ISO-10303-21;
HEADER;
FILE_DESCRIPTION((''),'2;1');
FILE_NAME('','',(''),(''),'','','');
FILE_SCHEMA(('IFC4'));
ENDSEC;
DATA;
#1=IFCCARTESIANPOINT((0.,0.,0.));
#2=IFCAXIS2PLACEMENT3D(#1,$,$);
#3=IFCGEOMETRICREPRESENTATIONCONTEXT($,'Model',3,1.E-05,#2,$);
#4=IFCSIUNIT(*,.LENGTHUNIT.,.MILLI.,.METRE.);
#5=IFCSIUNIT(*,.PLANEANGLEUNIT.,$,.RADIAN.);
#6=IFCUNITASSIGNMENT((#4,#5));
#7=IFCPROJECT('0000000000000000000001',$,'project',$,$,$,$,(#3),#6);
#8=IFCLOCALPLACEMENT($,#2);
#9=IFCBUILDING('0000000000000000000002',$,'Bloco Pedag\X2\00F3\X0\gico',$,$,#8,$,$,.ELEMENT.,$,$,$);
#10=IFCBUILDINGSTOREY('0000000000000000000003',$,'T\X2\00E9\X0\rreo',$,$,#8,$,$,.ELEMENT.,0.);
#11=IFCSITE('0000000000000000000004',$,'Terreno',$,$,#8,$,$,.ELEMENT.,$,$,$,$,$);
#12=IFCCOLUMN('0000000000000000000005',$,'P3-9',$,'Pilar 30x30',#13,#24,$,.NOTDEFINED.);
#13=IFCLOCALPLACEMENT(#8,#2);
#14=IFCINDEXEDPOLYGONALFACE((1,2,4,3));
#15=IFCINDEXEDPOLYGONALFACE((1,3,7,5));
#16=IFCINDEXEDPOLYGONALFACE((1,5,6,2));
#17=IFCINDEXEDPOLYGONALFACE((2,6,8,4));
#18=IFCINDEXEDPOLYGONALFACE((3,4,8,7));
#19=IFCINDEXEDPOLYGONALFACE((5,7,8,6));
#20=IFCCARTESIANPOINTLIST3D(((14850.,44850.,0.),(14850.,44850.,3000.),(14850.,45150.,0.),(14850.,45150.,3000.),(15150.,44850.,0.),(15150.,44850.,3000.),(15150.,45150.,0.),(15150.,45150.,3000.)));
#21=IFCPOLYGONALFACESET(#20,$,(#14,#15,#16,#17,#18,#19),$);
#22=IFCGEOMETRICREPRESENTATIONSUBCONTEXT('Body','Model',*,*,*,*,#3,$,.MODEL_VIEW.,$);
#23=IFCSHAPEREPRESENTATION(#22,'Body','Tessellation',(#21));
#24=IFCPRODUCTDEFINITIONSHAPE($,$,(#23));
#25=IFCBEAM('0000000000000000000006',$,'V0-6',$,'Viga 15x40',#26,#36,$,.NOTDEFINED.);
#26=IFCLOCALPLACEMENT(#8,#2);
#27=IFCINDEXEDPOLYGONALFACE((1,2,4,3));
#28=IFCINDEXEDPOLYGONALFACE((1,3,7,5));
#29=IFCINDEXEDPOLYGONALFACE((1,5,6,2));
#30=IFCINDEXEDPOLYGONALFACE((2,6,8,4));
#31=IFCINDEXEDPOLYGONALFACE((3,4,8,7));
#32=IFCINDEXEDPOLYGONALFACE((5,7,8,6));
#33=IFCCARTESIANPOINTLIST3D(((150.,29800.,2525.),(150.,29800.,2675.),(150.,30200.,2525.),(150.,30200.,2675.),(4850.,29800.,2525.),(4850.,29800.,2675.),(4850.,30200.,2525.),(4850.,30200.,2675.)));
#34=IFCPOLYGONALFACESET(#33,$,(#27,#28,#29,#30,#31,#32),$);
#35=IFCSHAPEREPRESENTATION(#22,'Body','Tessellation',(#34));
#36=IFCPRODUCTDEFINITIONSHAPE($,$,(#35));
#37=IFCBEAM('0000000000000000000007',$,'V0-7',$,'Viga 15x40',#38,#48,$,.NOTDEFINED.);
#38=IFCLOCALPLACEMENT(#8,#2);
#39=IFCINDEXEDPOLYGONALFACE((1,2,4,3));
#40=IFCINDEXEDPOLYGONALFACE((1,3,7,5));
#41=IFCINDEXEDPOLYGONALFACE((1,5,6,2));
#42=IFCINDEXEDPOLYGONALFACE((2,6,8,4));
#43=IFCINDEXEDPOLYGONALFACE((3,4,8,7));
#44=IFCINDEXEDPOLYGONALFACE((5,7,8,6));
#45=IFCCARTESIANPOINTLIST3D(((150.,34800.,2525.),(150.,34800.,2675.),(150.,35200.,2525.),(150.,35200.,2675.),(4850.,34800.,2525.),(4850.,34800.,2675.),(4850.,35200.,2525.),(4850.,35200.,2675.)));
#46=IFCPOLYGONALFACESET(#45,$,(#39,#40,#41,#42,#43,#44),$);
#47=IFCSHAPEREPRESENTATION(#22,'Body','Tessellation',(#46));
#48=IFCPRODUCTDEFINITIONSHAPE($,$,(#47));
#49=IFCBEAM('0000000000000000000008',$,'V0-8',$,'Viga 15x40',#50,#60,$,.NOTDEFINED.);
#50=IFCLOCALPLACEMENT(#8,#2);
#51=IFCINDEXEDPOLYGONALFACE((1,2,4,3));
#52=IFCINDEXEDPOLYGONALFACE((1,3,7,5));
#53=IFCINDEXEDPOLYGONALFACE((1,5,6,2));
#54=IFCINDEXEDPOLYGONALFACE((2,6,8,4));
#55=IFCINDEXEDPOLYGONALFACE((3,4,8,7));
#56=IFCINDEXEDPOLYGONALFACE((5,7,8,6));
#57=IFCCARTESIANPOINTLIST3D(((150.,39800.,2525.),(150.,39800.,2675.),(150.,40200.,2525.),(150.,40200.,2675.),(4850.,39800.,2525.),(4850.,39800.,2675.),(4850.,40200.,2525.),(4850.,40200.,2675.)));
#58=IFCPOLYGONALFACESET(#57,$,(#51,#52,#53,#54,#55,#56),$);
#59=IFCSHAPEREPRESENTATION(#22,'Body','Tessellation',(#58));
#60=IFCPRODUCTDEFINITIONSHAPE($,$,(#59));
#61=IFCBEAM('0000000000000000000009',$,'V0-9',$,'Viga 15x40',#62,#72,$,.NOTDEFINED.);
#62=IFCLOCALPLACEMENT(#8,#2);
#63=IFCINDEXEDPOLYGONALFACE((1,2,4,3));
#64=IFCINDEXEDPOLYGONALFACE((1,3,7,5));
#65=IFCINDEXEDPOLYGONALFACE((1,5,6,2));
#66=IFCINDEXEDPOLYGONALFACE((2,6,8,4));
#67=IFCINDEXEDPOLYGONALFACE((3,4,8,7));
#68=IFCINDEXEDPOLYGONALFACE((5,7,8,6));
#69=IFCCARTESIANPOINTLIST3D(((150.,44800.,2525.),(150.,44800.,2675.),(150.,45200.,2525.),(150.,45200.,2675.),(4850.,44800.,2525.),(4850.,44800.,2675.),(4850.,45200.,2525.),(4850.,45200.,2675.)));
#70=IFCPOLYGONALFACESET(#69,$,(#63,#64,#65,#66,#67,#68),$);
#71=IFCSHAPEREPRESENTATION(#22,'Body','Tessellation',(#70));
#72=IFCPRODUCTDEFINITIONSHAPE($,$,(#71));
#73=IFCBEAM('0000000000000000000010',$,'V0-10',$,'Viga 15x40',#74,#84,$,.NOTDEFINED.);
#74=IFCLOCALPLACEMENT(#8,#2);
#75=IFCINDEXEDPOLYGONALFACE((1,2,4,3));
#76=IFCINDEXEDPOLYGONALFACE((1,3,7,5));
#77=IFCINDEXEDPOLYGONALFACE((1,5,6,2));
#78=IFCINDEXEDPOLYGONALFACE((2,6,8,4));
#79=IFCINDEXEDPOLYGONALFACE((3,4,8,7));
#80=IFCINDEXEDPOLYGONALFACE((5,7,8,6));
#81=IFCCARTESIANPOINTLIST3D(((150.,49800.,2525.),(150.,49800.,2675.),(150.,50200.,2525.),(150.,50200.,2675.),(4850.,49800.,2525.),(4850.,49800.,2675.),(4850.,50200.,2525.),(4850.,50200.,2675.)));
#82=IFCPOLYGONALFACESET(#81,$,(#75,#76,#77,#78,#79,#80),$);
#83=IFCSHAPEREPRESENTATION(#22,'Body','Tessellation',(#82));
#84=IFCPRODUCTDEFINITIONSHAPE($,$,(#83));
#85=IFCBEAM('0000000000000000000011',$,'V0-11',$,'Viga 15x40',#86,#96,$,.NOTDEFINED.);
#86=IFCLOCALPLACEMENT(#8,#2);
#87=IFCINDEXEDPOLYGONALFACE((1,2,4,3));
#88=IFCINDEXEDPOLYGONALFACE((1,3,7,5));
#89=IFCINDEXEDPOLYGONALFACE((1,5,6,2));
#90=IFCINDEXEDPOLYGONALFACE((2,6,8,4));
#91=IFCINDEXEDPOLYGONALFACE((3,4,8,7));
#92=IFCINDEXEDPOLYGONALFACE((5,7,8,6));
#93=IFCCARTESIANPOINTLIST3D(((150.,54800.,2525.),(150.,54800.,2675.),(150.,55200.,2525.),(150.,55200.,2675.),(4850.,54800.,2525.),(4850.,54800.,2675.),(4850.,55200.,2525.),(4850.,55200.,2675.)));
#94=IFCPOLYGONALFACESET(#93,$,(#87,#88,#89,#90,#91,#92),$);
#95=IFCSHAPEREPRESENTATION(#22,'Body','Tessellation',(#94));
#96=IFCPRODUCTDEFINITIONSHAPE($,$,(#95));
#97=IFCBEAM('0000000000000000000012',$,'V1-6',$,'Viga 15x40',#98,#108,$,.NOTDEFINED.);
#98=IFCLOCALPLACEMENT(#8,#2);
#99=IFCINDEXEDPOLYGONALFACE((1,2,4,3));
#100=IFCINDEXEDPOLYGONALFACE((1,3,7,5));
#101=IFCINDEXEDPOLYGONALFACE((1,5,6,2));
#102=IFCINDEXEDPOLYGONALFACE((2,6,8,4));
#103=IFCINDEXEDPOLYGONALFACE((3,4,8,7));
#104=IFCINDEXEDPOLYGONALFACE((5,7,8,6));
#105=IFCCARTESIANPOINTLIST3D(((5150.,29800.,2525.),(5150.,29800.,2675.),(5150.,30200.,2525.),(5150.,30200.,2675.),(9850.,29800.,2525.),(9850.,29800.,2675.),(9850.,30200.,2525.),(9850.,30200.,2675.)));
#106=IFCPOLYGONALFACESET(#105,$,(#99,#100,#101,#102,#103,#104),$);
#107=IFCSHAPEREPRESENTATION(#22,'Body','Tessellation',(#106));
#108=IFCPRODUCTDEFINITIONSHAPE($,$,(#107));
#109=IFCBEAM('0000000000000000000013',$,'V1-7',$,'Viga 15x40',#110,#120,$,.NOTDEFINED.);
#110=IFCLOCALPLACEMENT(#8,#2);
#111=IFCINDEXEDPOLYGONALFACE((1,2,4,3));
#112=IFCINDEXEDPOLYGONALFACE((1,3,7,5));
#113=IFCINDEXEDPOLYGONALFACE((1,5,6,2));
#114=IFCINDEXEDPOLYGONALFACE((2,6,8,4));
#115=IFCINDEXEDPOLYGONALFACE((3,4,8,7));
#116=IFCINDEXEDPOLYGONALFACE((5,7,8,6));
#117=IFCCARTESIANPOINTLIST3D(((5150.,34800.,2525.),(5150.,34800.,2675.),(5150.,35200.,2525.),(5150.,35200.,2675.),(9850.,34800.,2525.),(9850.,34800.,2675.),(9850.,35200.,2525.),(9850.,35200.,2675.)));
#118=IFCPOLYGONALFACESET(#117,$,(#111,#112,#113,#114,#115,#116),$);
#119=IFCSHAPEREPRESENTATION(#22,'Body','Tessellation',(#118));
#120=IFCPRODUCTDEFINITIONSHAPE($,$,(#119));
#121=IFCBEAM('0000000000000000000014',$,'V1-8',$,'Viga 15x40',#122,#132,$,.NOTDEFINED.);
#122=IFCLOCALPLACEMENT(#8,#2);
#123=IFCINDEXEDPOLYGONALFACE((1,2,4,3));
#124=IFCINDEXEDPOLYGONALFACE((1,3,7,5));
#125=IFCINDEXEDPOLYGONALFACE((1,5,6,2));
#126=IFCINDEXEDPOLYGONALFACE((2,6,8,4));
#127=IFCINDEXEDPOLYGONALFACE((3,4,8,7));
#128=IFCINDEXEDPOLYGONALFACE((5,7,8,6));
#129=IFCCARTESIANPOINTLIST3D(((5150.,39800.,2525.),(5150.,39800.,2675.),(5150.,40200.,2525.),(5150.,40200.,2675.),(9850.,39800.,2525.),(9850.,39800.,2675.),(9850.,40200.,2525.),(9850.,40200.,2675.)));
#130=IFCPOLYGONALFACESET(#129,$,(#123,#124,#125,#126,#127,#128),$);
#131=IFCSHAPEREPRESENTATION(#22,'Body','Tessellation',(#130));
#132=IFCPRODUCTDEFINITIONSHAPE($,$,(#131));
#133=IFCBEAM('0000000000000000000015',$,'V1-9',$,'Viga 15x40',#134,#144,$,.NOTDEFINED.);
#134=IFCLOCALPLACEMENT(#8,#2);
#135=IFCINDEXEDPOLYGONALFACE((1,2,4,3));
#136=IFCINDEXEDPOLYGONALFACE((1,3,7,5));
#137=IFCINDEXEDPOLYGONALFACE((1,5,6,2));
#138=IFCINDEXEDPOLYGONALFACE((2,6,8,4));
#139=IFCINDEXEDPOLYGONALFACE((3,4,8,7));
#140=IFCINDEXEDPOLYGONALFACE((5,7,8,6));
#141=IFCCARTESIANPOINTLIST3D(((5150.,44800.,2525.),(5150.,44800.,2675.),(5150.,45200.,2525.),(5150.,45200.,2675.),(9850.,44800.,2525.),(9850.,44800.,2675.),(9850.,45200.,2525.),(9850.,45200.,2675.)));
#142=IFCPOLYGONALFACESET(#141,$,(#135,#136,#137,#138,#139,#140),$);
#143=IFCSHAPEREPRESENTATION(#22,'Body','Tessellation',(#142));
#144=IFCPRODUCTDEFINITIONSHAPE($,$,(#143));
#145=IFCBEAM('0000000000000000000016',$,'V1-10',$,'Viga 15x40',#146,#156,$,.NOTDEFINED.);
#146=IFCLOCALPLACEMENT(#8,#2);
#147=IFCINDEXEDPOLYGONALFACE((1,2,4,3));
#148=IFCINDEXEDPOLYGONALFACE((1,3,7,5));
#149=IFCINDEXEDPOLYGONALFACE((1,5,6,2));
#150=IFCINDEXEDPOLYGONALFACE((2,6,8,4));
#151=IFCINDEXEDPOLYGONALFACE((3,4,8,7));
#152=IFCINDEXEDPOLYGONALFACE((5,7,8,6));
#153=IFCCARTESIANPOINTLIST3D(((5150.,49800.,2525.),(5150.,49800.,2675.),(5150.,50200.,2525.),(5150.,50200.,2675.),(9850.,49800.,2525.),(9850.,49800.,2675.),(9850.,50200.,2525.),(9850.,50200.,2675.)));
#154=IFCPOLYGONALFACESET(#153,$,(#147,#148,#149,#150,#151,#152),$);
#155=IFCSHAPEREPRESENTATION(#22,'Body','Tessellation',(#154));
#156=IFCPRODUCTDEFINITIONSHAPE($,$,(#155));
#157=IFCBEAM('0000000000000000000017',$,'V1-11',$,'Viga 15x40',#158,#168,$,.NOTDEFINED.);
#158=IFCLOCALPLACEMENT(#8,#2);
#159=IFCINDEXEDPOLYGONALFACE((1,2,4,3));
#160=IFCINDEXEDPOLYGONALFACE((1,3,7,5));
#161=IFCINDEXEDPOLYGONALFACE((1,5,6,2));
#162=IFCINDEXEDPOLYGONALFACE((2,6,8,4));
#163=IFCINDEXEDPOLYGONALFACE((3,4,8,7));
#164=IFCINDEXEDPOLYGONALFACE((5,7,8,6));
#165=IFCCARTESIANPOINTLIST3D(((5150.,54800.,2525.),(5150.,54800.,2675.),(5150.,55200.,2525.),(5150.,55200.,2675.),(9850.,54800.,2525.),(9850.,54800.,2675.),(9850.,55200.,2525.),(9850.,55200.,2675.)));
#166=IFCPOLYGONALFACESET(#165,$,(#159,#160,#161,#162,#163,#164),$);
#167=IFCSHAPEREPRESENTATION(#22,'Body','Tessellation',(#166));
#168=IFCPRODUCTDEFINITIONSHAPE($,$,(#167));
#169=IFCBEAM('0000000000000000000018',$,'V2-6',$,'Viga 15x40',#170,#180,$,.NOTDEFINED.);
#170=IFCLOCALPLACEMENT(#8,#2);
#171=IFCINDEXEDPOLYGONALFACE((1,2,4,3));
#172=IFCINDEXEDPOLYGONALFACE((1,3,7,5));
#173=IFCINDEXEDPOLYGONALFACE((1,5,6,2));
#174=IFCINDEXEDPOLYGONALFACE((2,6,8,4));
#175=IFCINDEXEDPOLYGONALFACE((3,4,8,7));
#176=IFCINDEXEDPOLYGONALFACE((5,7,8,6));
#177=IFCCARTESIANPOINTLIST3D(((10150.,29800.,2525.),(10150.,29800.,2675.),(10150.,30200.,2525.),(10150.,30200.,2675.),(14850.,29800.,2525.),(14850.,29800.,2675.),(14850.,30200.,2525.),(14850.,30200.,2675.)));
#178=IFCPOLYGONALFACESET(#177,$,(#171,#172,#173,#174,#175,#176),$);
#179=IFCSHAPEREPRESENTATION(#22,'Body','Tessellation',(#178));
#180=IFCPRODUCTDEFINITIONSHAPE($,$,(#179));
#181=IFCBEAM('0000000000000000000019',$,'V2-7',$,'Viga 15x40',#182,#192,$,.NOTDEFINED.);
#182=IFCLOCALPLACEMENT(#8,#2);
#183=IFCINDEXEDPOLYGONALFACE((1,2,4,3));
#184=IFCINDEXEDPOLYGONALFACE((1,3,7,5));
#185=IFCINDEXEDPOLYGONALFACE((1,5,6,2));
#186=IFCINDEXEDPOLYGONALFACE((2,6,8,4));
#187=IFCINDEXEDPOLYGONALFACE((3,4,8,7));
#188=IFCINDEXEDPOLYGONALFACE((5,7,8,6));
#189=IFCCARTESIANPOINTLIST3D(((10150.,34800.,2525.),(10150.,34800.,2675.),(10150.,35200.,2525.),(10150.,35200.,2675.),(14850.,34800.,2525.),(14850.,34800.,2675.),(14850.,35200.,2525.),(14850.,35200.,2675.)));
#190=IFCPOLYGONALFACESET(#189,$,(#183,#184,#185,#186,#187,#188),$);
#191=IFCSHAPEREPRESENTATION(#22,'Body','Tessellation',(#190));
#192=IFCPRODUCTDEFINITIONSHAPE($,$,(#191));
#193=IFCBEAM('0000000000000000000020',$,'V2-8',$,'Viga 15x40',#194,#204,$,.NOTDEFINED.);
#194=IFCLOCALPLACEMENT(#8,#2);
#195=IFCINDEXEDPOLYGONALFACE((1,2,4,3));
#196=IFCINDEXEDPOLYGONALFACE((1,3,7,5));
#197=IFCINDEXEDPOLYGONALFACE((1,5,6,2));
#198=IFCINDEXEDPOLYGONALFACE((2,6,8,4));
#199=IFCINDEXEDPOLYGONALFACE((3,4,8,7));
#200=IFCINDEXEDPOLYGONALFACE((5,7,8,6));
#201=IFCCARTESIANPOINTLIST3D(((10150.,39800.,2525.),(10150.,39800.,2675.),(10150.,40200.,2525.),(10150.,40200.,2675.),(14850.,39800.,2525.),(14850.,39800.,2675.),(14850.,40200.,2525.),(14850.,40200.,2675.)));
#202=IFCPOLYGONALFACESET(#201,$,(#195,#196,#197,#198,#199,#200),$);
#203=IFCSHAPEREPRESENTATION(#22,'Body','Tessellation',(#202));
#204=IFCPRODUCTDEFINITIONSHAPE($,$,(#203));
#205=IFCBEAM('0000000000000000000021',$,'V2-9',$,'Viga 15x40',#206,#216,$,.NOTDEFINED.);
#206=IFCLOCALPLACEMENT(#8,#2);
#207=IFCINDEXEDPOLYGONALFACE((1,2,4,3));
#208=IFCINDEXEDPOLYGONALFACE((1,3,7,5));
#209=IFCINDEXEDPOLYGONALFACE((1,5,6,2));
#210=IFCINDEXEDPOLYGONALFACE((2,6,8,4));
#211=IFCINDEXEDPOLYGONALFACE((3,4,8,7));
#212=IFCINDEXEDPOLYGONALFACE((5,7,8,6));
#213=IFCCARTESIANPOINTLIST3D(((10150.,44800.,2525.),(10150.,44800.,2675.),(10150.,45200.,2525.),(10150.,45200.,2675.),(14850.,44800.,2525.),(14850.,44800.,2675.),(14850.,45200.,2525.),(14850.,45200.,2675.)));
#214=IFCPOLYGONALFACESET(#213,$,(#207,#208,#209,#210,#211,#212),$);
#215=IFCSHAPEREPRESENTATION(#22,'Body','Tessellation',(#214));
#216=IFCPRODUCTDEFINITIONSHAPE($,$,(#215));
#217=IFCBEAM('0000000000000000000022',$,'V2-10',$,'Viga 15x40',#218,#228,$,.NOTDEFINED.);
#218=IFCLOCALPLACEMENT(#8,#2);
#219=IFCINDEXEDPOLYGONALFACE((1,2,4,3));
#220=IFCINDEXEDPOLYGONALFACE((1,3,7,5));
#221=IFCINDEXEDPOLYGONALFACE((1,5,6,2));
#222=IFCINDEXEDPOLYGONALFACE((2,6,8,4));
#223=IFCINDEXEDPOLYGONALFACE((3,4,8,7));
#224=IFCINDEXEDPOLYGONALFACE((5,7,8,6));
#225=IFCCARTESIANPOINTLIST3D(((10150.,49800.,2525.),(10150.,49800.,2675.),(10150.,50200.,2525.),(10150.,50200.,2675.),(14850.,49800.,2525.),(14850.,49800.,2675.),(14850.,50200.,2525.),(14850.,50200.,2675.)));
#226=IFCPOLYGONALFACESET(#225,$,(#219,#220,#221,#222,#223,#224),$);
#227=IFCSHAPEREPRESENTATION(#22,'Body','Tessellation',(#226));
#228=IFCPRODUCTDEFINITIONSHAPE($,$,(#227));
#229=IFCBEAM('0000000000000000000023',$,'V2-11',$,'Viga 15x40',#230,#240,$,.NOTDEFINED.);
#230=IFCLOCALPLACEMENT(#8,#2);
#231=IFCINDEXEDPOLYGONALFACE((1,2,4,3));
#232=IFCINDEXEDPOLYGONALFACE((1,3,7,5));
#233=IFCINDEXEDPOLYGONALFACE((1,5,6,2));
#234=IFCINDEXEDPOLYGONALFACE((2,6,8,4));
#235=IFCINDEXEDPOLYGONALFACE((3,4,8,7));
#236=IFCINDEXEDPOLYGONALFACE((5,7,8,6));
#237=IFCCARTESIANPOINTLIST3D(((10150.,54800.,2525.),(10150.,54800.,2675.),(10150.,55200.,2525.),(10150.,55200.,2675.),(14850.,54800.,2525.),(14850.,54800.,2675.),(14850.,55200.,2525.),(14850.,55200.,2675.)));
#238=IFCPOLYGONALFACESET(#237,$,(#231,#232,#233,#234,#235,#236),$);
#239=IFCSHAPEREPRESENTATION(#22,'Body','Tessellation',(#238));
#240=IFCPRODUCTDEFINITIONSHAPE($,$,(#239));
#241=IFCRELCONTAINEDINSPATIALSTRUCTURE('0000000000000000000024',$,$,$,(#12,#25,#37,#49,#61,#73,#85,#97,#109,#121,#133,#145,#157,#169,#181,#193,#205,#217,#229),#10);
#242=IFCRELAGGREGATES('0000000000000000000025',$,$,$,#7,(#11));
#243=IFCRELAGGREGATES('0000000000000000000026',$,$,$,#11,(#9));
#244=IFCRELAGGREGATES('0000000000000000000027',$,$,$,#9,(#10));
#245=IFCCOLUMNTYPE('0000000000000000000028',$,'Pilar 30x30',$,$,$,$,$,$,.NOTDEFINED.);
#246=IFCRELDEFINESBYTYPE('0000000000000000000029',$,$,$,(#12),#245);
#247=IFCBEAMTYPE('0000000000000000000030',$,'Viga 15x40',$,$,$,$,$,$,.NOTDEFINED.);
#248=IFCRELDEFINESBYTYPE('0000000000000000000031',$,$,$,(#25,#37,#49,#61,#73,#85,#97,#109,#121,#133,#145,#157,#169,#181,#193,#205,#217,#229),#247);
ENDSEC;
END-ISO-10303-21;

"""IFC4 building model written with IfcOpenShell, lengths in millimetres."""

from ifc_helpers import new_model, si_unit, frame, origin, origin_2d, place, context, subcontext, project, spatial, rectangle, extrude, type_object, element, save


model = new_model("IFC4")

# Units and contexts
model_context = context("Model", 3, precision=1e-05, world=origin())
body_context = subcontext(model_context, "Body", "Model", "MODEL_VIEW")
ifc_project = project(units=[si_unit("LENGTHUNIT", "METRE", prefix="MILLI"), si_unit("PLANEANGLEUNIT", "RADIAN")], contexts=[model_context])

# Site, building, storey
placement = place(None, origin())
site = spatial("IfcSite", under=ifc_project, at=placement, Name="Terreno", CompositionType="ELEMENT")
building = spatial("IfcBuilding", under=site, at=placement, Name="Bloco Pedagógico", CompositionType="ELEMENT")
storey = spatial("IfcBuildingStorey", under=building, at=placement, Name="Térreo", CompositionType="ELEMENT", Elevation=0.0)

# Column
column_type = type_object("IfcColumnType", Name="Pilar 30x30", PredefinedType="NOTDEFINED")
for number, where, z_axis, x_axis, name in (
    (1, (15000.0, 45000.0, 0.0), (0.0, 0.0, 1.0), (1.0, 0.0, 0.0), "P3-9"),
):
    element("IfcColumn", number, at=place(None, frame(where, z_axis=z_axis, x_axis=x_axis)), inside=storey, type_object=column_type, Name=name, ObjectType="Pilar 30x30", PredefinedType="NOTDEFINED", context=body_context, shape_type="SweptSolid", body=[
        extrude(rectangle(XDim=300.0, YDim=300.0, at=origin_2d()), None, (0.0, 0.0, 1.0), 3000.0),
    ])

# Beams
beam_type = type_object("IfcBeamType", Name="Viga 15x40", PredefinedType="NOTDEFINED")
for number, where, z_axis, x_axis, name in (
    (2, (150.0, 30000.0, 2600.0), (1.0, 0.0, 0.0), (0.0, 1.0, 0.0), "V0-6"),
    (3, (150.0, 35000.0, 2600.0), (1.0, 0.0, 0.0), (0.0, 1.0, 0.0), "V0-7"),
    (4, (150.0, 40000.0, 2600.0), (1.0, 0.0, 0.0), (0.0, 1.0, 0.0), "V0-8"),
    (5, (150.0, 45000.0, 2600.0), (1.0, 0.0, 0.0), (0.0, 1.0, 0.0), "V0-9"),
    (6, (150.0, 50000.0, 2600.0), (1.0, 0.0, 0.0), (0.0, 1.0, 0.0), "V0-10"),
    (7, (150.0, 55000.0, 2600.0), (1.0, 0.0, 0.0), (0.0, 1.0, 0.0), "V0-11"),
    (8, (5150.0, 30000.0, 2600.0), (1.0, 0.0, 0.0), (0.0, 1.0, 0.0), "V1-6"),
    (9, (5150.0, 35000.0, 2600.0), (1.0, 0.0, 0.0), (0.0, 1.0, 0.0), "V1-7"),
    (10, (5150.0, 40000.0, 2600.0), (1.0, 0.0, 0.0), (0.0, 1.0, 0.0), "V1-8"),
    (11, (5150.0, 45000.0, 2600.0), (1.0, 0.0, 0.0), (0.0, 1.0, 0.0), "V1-9"),
    (12, (5150.0, 50000.0, 2600.0), (1.0, 0.0, 0.0), (0.0, 1.0, 0.0), "V1-10"),
    (13, (5150.0, 55000.0, 2600.0), (1.0, 0.0, 0.0), (0.0, 1.0, 0.0), "V1-11"),
    (14, (10150.0, 30000.0, 2600.0), (1.0, 0.0, 0.0), (0.0, 1.0, 0.0), "V2-6"),
    (15, (10150.0, 35000.0, 2600.0), (1.0, 0.0, 0.0), (0.0, 1.0, 0.0), "V2-7"),
    (16, (10150.0, 40000.0, 2600.0), (1.0, 0.0, 0.0), (0.0, 1.0, 0.0), "V2-8"),
    (17, (10150.0, 45000.0, 2600.0), (1.0, 0.0, 0.0), (0.0, 1.0, 0.0), "V2-9"),
    (18, (10150.0, 50000.0, 2600.0), (1.0, 0.0, 0.0), (0.0, 1.0, 0.0), "V2-10"),
    (19, (10150.0, 55000.0, 2600.0), (1.0, 0.0, 0.0), (0.0, 1.0, 0.0), "V2-11"),
):
    element("IfcBeam", number, at=place(None, frame(where, z_axis=z_axis, x_axis=x_axis)), inside=storey, type_object=beam_type, Name=name, ObjectType="Viga 15x40", PredefinedType="NOTDEFINED", context=body_context, shape_type="SweptSolid", body=[
        extrude(rectangle(XDim=400.0, YDim=150.0, at=origin_2d()), None, (0.0, 0.0, 1.0), 4700.0),
    ])

save(model, "model.ifc")
